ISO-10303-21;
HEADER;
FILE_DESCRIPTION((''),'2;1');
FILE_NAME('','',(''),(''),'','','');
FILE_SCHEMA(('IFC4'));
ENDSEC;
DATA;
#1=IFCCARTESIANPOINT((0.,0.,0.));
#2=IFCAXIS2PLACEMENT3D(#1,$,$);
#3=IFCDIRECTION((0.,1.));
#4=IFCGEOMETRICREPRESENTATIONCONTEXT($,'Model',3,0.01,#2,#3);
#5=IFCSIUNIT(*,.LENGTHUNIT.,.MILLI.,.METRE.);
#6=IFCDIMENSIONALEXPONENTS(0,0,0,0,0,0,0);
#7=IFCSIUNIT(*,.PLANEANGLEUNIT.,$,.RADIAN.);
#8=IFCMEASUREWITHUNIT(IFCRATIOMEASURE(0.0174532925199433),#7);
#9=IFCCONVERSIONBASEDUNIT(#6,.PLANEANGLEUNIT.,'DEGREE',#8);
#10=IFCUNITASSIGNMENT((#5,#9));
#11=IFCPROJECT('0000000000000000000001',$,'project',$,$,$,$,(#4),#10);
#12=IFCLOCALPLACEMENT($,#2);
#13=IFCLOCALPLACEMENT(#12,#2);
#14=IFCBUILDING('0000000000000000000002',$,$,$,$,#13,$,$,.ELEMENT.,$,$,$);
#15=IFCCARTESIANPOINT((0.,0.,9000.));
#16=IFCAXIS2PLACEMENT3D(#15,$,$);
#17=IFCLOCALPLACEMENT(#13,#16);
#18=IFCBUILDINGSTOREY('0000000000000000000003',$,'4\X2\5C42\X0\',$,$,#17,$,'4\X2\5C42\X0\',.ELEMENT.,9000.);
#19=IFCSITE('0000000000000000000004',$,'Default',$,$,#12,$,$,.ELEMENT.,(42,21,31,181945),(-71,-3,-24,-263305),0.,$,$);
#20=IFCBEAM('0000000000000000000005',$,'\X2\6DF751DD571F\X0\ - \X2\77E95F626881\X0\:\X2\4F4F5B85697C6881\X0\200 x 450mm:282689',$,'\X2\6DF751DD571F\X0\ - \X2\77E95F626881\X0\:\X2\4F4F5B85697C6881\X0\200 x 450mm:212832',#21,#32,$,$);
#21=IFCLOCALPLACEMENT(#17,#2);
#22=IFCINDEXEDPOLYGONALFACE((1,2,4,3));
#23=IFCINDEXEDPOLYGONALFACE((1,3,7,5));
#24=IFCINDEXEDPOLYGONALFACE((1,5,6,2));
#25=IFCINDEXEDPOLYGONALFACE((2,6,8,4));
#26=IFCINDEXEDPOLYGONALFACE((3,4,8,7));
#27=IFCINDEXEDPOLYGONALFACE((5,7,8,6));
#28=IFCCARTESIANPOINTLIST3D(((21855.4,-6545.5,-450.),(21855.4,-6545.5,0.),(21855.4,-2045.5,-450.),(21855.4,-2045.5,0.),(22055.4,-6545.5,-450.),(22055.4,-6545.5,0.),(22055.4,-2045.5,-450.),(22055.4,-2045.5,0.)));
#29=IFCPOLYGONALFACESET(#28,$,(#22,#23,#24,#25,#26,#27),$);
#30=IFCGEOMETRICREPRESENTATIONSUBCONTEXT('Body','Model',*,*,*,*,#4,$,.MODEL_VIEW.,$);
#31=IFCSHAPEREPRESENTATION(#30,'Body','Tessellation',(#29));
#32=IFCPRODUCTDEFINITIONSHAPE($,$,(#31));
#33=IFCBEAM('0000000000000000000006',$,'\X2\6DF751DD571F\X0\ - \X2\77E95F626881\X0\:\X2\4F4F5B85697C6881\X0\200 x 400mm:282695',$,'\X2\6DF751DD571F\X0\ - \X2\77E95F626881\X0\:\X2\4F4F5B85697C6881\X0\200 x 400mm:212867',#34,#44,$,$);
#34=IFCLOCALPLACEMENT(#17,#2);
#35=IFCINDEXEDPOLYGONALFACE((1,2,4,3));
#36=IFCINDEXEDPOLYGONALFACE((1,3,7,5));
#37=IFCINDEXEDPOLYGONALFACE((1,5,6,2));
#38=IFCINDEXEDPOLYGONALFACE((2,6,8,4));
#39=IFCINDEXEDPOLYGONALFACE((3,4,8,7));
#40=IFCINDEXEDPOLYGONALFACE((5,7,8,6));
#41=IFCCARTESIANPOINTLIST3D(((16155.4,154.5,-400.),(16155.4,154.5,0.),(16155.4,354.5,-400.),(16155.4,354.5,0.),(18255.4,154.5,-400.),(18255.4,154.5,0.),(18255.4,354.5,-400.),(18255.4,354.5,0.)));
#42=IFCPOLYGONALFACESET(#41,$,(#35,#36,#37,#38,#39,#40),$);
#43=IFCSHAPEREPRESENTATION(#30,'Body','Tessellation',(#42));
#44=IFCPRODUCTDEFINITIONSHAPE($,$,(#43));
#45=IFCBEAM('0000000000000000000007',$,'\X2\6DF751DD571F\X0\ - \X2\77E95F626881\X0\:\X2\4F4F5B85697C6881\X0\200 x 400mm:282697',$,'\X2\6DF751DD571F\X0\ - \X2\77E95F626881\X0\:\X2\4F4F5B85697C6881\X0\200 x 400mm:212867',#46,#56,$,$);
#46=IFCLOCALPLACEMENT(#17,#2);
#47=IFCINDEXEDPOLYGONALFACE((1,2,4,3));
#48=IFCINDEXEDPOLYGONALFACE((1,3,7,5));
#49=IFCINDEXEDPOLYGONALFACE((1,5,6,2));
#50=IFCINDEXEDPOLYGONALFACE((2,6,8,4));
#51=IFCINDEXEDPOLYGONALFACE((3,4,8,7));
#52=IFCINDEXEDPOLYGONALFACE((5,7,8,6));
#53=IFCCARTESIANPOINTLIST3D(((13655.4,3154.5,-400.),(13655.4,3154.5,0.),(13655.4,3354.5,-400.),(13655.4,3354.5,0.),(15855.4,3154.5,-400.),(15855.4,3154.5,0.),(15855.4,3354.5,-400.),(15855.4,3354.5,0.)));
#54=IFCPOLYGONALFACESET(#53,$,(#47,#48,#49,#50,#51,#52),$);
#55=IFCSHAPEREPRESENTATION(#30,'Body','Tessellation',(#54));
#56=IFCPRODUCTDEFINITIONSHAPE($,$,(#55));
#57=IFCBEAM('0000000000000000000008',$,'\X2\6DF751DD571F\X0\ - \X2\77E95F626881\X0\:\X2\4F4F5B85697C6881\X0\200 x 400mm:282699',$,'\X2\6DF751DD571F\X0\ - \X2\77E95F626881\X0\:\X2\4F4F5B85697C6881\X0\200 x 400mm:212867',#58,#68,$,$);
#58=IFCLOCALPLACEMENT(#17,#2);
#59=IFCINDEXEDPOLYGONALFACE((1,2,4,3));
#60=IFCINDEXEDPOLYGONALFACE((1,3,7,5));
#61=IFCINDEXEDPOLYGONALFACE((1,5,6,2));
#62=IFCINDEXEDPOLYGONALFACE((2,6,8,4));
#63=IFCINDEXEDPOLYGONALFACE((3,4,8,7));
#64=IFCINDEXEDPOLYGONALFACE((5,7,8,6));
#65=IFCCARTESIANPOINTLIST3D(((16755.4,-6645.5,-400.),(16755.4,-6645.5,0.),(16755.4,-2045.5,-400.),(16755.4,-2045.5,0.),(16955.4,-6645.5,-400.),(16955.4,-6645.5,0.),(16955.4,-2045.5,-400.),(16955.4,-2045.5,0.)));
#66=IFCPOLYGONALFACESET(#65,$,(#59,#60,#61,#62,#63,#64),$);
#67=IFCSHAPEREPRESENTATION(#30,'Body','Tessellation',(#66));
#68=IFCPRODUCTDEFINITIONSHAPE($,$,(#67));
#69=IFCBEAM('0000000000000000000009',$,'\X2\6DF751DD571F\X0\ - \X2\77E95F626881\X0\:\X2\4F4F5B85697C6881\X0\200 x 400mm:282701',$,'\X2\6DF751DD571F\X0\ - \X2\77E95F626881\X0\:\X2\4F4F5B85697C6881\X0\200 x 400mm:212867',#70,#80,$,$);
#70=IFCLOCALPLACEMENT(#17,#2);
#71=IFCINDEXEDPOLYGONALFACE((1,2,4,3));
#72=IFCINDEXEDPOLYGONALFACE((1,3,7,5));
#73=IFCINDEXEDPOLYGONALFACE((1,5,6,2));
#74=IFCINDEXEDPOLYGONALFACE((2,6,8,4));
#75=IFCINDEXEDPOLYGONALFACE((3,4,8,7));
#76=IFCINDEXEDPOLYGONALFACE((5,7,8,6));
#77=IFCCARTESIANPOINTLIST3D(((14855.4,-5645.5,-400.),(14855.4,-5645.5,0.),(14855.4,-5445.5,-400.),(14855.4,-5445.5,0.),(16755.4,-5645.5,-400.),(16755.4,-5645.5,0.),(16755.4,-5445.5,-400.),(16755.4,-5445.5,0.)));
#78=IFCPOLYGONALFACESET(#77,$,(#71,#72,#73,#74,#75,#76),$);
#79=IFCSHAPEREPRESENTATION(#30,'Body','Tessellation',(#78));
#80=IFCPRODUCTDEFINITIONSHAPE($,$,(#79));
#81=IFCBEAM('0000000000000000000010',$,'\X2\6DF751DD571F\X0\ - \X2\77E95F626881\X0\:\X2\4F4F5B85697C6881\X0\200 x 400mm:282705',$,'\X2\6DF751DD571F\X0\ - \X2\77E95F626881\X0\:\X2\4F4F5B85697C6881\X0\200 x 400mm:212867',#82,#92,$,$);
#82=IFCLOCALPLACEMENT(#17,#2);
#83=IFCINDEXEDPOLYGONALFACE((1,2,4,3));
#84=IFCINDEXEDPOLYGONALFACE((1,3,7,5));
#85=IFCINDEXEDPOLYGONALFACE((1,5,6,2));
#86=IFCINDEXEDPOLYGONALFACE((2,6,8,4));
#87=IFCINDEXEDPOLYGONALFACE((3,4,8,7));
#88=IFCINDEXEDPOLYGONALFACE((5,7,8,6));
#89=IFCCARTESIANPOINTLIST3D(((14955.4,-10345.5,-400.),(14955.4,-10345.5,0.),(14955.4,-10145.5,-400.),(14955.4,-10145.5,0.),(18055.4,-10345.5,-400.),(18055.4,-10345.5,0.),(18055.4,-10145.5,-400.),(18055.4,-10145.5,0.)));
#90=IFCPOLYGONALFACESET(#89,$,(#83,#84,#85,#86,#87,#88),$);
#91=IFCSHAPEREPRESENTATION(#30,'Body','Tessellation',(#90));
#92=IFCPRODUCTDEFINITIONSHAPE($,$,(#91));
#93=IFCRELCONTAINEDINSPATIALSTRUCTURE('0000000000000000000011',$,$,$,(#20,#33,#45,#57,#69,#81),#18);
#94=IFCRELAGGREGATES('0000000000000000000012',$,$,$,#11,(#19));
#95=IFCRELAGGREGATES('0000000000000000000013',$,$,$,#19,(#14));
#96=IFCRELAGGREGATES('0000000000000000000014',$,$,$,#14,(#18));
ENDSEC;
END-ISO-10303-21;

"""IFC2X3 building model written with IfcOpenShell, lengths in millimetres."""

from ifc_helpers import new_model, entity, si_unit, converted_unit, direction, frame, frame_2d, origin, origin_2d_with_axis, place, context, subcontext, project, spatial, rectangle, extrude, element, save


model = new_model("IFC2X3")

# Units and contexts
model_context = context("Model", 3, precision=0.01, world=origin(), true_north=direction((0.0, 1.0)))
body_context = subcontext(model_context, "Body", "Model", "MODEL_VIEW")
ifc_project = project(units=[si_unit("LENGTHUNIT", "METRE", prefix="MILLI"), converted_unit("PLANEANGLEUNIT", "DEGREE", entity("IfcRatioMeasure", 0.0174532925199433), si_unit("PLANEANGLEUNIT", "RADIAN"), dimensions=[0, 0, 0, 0, 0, 0, 0])], contexts=[model_context])

# Site, building, storey
site_placement = place(None, origin())
site = spatial("IfcSite", under=ifc_project, at=site_placement, Name="Default", CompositionType="ELEMENT", RefLatitude=(42, 21, 31, 181945), RefLongitude=(-71, -3, -24, -263305), RefElevation=0.0)
building_placement = place(site_placement, origin())
building = spatial("IfcBuilding", under=site, at=building_placement, CompositionType="ELEMENT")
storey_placement = place(building_placement, frame((0.0, 0.0, 9000.0)))
storey = spatial("IfcBuildingStorey", under=building, at=storey_placement, Name="4层", LongName="4层", CompositionType="ELEMENT", Elevation=9000.0)

# Beams
beam_1_placement = place(storey_placement, frame((21955.4, -1945.5, 0.0), z_axis=(0.0, 0.0, 1.0), x_axis=(0.0, -1.0, 0.0)))
element("IfcBeam", 1, at=beam_1_placement, inside=storey, Name="混凝土 - 矩形梁:住宅楼梁200 x 450mm:282689", ObjectType="混凝土 - 矩形梁:住宅楼梁200 x 450mm:212832", context=body_context, shape_type="SweptSolid", body=[
    extrude(rectangle(XDim=450.0, YDim=200.0, at=frame_2d((0.0, 0.0), x_axis=(1.0, 0.0))), frame((100.0, 0.0, -225.0), z_axis=(1.0, 0.0, 0.0), x_axis=(0.0, 0.0, -1.0)), (0.0, 0.0, 1.0), 4500.0),
])
beam_2_placement = place(storey_placement, frame((18355.4, 254.5, 0.0), z_axis=(0.0, 0.0, 1.0), x_axis=(-1.0, 0.0, 0.0)))
element("IfcBeam", 2, at=beam_2_placement, inside=storey, Name="混凝土 - 矩形梁:住宅楼梁200 x 400mm:282695", ObjectType="混凝土 - 矩形梁:住宅楼梁200 x 400mm:212867", context=body_context, shape_type="SweptSolid", body=[
    extrude(rectangle(XDim=400.0, YDim=200.0, at=frame_2d((0.0, 0.0), x_axis=(1.0, 0.0))), frame((100.0, 0.0, -200.0), z_axis=(1.0, 0.0, 0.0), x_axis=(0.0, 0.0, -1.0)), (0.0, 0.0, 1.0), 2100.0),
])
beam_3_placement = place(storey_placement, frame((16055.4, 3254.5, 0.0), z_axis=(0.0, 0.0, 1.0), x_axis=(-1.0, 0.0, 0.0)))
element("IfcBeam", 3, at=beam_3_placement, inside=storey, Name="混凝土 - 矩形梁:住宅楼梁200 x 400mm:282697", ObjectType="混凝土 - 矩形梁:住宅楼梁200 x 400mm:212867", context=body_context, shape_type="SweptSolid", body=[
    extrude(rectangle(XDim=400.0, YDim=200.0, at=frame_2d((0.0, 0.0), x_axis=(1.0, 0.0))), frame((200.0, 0.0, -200.0), z_axis=(1.0, 0.0, 0.0), x_axis=(0.0, 0.0, -1.0)), (0.0, 0.0, 1.0), 2200.0),
])
beam_4_placement = place(storey_placement, frame((16855.4, -1945.5, 0.0), z_axis=(0.0, 0.0, 1.0), x_axis=(0.0, -1.0, 0.0)))
element("IfcBeam", 4, at=beam_4_placement, inside=storey, Name="混凝土 - 矩形梁:住宅楼梁200 x 400mm:282699", ObjectType="混凝土 - 矩形梁:住宅楼梁200 x 400mm:212867", context=body_context, shape_type="SweptSolid", body=[
    extrude(rectangle(XDim=400.0, YDim=200.0, at=origin_2d_with_axis()), frame((100.0, 0.0, -200.0), z_axis=(1.0, 0.0, 0.0), x_axis=(0.0, 0.0, -1.0)), (0.0, 0.0, 1.0), 4600.0),
])
beam_5_placement = place(storey_placement, frame((16855.4, -5545.5, 0.0), z_axis=(0.0, 0.0, 1.0), x_axis=(-1.0, 0.0, 0.0)))
element("IfcBeam", 5, at=beam_5_placement, inside=storey, Name="混凝土 - 矩形梁:住宅楼梁200 x 400mm:282701", ObjectType="混凝土 - 矩形梁:住宅楼梁200 x 400mm:212867", context=body_context, shape_type="SweptSolid", body=[
    extrude(rectangle(XDim=400.0, YDim=200.0, at=frame_2d((0.0, 0.0), x_axis=(1.0, 0.0))), frame((100.0, 0.0, -200.0), z_axis=(1.0, 0.0, 0.0), x_axis=(0.0, 0.0, -1.0)), (0.0, 0.0, 1.0), 1900.0),
])
beam_6_placement = place(storey_placement, frame((18055.4, -10245.5, 0.0), z_axis=(0.0, 0.0, 1.0), x_axis=(-1.0, 0.0, 0.0)))
element("IfcBeam", 6, at=beam_6_placement, inside=storey, Name="混凝土 - 矩形梁:住宅楼梁200 x 400mm:282705", ObjectType="混凝土 - 矩形梁:住宅楼梁200 x 400mm:212867", context=body_context, shape_type="SweptSolid", body=[
    extrude(rectangle(XDim=400.0, YDim=200.0, at=frame_2d((0.0, 0.0), x_axis=(1.0, 0.0))), frame((0.0, 0.0, -200.0), z_axis=(1.0, 0.0, 0.0), x_axis=(0.0, 0.0, -1.0)), (0.0, 0.0, 1.0), 3100.0),
])

save(model, "model.ifc")
